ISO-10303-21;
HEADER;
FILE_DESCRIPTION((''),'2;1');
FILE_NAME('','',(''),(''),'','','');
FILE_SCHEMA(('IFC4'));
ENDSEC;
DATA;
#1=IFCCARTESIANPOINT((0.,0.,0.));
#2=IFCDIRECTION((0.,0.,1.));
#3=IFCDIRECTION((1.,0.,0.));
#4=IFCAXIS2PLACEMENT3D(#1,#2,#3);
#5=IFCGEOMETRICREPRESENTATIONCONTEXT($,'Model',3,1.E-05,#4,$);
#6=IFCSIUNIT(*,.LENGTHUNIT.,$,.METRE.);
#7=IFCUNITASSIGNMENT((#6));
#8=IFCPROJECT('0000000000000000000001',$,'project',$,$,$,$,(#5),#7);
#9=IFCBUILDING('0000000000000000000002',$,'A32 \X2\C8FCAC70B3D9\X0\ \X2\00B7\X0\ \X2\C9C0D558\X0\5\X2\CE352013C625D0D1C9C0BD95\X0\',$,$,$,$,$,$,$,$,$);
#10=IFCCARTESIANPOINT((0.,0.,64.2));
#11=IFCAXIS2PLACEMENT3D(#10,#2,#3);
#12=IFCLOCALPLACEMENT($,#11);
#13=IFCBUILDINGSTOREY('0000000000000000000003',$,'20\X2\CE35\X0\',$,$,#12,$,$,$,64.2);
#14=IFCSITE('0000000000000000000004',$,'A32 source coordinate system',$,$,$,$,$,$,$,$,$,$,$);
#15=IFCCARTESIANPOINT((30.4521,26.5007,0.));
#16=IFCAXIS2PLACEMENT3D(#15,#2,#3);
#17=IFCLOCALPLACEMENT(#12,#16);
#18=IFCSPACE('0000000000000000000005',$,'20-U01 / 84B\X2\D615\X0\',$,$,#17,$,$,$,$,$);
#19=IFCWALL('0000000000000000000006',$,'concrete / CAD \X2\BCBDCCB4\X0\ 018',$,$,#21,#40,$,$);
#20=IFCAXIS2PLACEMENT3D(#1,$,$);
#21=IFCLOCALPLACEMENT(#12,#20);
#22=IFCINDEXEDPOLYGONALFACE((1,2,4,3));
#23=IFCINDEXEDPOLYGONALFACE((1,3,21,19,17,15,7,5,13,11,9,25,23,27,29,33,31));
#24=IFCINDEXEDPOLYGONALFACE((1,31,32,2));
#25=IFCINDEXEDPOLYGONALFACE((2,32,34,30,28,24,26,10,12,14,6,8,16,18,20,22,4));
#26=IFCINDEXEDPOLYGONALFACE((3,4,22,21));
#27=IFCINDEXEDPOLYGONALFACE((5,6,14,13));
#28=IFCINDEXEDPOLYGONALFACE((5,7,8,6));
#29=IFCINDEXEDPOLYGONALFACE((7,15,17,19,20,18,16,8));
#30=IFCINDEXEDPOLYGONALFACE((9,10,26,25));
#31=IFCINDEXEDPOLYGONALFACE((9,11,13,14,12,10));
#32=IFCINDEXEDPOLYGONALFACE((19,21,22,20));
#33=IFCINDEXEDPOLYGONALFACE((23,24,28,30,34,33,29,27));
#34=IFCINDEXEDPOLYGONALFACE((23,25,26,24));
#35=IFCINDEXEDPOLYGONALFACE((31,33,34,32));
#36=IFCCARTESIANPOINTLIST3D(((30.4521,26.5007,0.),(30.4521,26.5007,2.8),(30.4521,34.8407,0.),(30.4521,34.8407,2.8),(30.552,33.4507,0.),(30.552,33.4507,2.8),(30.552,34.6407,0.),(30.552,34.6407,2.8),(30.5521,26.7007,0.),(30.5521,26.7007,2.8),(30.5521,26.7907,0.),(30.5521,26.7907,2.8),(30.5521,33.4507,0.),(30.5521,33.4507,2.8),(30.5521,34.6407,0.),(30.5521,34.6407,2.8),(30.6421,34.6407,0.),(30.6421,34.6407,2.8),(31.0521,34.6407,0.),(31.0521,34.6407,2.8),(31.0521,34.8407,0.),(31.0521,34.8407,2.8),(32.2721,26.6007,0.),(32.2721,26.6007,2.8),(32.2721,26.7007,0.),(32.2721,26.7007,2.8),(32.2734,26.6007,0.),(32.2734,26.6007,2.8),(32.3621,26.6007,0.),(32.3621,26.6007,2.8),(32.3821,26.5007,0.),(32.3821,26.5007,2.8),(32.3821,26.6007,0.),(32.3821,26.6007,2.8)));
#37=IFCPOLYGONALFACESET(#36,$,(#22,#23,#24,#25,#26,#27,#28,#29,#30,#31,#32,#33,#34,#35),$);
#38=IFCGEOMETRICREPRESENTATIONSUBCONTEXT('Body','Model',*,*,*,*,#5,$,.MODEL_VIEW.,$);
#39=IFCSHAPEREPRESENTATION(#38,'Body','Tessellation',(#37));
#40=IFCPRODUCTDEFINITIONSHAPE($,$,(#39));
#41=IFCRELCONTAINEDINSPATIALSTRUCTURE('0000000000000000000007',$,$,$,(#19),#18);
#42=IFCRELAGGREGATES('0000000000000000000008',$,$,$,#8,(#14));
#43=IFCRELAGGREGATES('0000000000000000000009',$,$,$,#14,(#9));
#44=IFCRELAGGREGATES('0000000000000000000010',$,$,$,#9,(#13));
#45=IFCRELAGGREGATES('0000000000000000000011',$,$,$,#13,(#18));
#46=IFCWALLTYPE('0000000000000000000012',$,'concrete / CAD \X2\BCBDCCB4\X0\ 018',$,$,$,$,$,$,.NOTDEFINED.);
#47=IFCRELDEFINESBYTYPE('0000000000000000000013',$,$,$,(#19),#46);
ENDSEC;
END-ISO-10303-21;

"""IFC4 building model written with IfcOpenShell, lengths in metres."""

from ifc_helpers import new_model, si_unit, frame, origin, origin_with_axes, place, context, subcontext, project, spatial, polyline, outline, extrude, source, transform, mapped, type_object, type_shapes, element, save


model = new_model("IFC4")

# Units and contexts
model_context = context("Model", 3, precision=1e-05, world=origin_with_axes())
body_context = subcontext(model_context, "Body", "Model", "MODEL_VIEW")
ifc_project = project(units=[si_unit("LENGTHUNIT", "METRE")], contexts=[model_context])

# Site, building, storey, space
site = spatial("IfcSite", under=ifc_project, Name="A32 source coordinate system")
building = spatial("IfcBuilding", under=site, Name="A32 주거동 · 지하5층–옥탑지붕")
storey_placement = place(None, frame((0.0, 0.0, 64.2), z_axis=(0.0, 0.0, 1.0), x_axis=(1.0, 0.0, 0.0)))
storey = spatial("IfcBuildingStorey", under=building, at=storey_placement, Name="20층", Elevation=64.2)
space_1_placement = place(storey_placement, frame((30.4521, 26.5007, 0.0), z_axis=(0.0, 0.0, 1.0), x_axis=(1.0, 0.0, 0.0)))
space_1 = spatial("IfcSpace", under=storey, at=space_1_placement, Name="20-U01 / 84B형")

# Wall
wall_type_1 = type_object("IfcWallType", Name="concrete / CAD 벽체 018", PredefinedType="NOTDEFINED")
shared_shape_1 = source(origin(), body_context, "Body", "SweptSolid", [
    extrude(outline(polyline([(0.6, 8.34), (0.6, 8.14), (0.19, 8.14), (0.1, 8.14), (0.0999, 8.14), (0.0999, 6.95), (0.1, 6.95), (0.1, 0.29), (0.1, 0.2), (1.82, 0.2), (1.82, 0.1), (1.8213, 0.1), (1.91, 0.1), (1.93, 0.1), (1.93, 0.0), (0.0, 0.0), (0.0, 8.34), (-0.35, 8.34), (-0.35, 8.34), (0.6, 8.34)])), origin(), (0.0, 0.0, 1.0), 2.8),
])
type_shapes(wall_type_1, [shared_shape_1])
wall_1_placement = place(space_1_placement, origin_with_axes())
element("IfcWall", 1, at=wall_1_placement, inside=space_1, type_object=wall_type_1, Name="concrete / CAD 벽체 018", context=body_context, shape_type="MappedRepresentation", body=[
    mapped(shared_shape_1, transform((0.0, 0.0, 0.0), scale=1.0)),
])

save(model, "model.ifc")
